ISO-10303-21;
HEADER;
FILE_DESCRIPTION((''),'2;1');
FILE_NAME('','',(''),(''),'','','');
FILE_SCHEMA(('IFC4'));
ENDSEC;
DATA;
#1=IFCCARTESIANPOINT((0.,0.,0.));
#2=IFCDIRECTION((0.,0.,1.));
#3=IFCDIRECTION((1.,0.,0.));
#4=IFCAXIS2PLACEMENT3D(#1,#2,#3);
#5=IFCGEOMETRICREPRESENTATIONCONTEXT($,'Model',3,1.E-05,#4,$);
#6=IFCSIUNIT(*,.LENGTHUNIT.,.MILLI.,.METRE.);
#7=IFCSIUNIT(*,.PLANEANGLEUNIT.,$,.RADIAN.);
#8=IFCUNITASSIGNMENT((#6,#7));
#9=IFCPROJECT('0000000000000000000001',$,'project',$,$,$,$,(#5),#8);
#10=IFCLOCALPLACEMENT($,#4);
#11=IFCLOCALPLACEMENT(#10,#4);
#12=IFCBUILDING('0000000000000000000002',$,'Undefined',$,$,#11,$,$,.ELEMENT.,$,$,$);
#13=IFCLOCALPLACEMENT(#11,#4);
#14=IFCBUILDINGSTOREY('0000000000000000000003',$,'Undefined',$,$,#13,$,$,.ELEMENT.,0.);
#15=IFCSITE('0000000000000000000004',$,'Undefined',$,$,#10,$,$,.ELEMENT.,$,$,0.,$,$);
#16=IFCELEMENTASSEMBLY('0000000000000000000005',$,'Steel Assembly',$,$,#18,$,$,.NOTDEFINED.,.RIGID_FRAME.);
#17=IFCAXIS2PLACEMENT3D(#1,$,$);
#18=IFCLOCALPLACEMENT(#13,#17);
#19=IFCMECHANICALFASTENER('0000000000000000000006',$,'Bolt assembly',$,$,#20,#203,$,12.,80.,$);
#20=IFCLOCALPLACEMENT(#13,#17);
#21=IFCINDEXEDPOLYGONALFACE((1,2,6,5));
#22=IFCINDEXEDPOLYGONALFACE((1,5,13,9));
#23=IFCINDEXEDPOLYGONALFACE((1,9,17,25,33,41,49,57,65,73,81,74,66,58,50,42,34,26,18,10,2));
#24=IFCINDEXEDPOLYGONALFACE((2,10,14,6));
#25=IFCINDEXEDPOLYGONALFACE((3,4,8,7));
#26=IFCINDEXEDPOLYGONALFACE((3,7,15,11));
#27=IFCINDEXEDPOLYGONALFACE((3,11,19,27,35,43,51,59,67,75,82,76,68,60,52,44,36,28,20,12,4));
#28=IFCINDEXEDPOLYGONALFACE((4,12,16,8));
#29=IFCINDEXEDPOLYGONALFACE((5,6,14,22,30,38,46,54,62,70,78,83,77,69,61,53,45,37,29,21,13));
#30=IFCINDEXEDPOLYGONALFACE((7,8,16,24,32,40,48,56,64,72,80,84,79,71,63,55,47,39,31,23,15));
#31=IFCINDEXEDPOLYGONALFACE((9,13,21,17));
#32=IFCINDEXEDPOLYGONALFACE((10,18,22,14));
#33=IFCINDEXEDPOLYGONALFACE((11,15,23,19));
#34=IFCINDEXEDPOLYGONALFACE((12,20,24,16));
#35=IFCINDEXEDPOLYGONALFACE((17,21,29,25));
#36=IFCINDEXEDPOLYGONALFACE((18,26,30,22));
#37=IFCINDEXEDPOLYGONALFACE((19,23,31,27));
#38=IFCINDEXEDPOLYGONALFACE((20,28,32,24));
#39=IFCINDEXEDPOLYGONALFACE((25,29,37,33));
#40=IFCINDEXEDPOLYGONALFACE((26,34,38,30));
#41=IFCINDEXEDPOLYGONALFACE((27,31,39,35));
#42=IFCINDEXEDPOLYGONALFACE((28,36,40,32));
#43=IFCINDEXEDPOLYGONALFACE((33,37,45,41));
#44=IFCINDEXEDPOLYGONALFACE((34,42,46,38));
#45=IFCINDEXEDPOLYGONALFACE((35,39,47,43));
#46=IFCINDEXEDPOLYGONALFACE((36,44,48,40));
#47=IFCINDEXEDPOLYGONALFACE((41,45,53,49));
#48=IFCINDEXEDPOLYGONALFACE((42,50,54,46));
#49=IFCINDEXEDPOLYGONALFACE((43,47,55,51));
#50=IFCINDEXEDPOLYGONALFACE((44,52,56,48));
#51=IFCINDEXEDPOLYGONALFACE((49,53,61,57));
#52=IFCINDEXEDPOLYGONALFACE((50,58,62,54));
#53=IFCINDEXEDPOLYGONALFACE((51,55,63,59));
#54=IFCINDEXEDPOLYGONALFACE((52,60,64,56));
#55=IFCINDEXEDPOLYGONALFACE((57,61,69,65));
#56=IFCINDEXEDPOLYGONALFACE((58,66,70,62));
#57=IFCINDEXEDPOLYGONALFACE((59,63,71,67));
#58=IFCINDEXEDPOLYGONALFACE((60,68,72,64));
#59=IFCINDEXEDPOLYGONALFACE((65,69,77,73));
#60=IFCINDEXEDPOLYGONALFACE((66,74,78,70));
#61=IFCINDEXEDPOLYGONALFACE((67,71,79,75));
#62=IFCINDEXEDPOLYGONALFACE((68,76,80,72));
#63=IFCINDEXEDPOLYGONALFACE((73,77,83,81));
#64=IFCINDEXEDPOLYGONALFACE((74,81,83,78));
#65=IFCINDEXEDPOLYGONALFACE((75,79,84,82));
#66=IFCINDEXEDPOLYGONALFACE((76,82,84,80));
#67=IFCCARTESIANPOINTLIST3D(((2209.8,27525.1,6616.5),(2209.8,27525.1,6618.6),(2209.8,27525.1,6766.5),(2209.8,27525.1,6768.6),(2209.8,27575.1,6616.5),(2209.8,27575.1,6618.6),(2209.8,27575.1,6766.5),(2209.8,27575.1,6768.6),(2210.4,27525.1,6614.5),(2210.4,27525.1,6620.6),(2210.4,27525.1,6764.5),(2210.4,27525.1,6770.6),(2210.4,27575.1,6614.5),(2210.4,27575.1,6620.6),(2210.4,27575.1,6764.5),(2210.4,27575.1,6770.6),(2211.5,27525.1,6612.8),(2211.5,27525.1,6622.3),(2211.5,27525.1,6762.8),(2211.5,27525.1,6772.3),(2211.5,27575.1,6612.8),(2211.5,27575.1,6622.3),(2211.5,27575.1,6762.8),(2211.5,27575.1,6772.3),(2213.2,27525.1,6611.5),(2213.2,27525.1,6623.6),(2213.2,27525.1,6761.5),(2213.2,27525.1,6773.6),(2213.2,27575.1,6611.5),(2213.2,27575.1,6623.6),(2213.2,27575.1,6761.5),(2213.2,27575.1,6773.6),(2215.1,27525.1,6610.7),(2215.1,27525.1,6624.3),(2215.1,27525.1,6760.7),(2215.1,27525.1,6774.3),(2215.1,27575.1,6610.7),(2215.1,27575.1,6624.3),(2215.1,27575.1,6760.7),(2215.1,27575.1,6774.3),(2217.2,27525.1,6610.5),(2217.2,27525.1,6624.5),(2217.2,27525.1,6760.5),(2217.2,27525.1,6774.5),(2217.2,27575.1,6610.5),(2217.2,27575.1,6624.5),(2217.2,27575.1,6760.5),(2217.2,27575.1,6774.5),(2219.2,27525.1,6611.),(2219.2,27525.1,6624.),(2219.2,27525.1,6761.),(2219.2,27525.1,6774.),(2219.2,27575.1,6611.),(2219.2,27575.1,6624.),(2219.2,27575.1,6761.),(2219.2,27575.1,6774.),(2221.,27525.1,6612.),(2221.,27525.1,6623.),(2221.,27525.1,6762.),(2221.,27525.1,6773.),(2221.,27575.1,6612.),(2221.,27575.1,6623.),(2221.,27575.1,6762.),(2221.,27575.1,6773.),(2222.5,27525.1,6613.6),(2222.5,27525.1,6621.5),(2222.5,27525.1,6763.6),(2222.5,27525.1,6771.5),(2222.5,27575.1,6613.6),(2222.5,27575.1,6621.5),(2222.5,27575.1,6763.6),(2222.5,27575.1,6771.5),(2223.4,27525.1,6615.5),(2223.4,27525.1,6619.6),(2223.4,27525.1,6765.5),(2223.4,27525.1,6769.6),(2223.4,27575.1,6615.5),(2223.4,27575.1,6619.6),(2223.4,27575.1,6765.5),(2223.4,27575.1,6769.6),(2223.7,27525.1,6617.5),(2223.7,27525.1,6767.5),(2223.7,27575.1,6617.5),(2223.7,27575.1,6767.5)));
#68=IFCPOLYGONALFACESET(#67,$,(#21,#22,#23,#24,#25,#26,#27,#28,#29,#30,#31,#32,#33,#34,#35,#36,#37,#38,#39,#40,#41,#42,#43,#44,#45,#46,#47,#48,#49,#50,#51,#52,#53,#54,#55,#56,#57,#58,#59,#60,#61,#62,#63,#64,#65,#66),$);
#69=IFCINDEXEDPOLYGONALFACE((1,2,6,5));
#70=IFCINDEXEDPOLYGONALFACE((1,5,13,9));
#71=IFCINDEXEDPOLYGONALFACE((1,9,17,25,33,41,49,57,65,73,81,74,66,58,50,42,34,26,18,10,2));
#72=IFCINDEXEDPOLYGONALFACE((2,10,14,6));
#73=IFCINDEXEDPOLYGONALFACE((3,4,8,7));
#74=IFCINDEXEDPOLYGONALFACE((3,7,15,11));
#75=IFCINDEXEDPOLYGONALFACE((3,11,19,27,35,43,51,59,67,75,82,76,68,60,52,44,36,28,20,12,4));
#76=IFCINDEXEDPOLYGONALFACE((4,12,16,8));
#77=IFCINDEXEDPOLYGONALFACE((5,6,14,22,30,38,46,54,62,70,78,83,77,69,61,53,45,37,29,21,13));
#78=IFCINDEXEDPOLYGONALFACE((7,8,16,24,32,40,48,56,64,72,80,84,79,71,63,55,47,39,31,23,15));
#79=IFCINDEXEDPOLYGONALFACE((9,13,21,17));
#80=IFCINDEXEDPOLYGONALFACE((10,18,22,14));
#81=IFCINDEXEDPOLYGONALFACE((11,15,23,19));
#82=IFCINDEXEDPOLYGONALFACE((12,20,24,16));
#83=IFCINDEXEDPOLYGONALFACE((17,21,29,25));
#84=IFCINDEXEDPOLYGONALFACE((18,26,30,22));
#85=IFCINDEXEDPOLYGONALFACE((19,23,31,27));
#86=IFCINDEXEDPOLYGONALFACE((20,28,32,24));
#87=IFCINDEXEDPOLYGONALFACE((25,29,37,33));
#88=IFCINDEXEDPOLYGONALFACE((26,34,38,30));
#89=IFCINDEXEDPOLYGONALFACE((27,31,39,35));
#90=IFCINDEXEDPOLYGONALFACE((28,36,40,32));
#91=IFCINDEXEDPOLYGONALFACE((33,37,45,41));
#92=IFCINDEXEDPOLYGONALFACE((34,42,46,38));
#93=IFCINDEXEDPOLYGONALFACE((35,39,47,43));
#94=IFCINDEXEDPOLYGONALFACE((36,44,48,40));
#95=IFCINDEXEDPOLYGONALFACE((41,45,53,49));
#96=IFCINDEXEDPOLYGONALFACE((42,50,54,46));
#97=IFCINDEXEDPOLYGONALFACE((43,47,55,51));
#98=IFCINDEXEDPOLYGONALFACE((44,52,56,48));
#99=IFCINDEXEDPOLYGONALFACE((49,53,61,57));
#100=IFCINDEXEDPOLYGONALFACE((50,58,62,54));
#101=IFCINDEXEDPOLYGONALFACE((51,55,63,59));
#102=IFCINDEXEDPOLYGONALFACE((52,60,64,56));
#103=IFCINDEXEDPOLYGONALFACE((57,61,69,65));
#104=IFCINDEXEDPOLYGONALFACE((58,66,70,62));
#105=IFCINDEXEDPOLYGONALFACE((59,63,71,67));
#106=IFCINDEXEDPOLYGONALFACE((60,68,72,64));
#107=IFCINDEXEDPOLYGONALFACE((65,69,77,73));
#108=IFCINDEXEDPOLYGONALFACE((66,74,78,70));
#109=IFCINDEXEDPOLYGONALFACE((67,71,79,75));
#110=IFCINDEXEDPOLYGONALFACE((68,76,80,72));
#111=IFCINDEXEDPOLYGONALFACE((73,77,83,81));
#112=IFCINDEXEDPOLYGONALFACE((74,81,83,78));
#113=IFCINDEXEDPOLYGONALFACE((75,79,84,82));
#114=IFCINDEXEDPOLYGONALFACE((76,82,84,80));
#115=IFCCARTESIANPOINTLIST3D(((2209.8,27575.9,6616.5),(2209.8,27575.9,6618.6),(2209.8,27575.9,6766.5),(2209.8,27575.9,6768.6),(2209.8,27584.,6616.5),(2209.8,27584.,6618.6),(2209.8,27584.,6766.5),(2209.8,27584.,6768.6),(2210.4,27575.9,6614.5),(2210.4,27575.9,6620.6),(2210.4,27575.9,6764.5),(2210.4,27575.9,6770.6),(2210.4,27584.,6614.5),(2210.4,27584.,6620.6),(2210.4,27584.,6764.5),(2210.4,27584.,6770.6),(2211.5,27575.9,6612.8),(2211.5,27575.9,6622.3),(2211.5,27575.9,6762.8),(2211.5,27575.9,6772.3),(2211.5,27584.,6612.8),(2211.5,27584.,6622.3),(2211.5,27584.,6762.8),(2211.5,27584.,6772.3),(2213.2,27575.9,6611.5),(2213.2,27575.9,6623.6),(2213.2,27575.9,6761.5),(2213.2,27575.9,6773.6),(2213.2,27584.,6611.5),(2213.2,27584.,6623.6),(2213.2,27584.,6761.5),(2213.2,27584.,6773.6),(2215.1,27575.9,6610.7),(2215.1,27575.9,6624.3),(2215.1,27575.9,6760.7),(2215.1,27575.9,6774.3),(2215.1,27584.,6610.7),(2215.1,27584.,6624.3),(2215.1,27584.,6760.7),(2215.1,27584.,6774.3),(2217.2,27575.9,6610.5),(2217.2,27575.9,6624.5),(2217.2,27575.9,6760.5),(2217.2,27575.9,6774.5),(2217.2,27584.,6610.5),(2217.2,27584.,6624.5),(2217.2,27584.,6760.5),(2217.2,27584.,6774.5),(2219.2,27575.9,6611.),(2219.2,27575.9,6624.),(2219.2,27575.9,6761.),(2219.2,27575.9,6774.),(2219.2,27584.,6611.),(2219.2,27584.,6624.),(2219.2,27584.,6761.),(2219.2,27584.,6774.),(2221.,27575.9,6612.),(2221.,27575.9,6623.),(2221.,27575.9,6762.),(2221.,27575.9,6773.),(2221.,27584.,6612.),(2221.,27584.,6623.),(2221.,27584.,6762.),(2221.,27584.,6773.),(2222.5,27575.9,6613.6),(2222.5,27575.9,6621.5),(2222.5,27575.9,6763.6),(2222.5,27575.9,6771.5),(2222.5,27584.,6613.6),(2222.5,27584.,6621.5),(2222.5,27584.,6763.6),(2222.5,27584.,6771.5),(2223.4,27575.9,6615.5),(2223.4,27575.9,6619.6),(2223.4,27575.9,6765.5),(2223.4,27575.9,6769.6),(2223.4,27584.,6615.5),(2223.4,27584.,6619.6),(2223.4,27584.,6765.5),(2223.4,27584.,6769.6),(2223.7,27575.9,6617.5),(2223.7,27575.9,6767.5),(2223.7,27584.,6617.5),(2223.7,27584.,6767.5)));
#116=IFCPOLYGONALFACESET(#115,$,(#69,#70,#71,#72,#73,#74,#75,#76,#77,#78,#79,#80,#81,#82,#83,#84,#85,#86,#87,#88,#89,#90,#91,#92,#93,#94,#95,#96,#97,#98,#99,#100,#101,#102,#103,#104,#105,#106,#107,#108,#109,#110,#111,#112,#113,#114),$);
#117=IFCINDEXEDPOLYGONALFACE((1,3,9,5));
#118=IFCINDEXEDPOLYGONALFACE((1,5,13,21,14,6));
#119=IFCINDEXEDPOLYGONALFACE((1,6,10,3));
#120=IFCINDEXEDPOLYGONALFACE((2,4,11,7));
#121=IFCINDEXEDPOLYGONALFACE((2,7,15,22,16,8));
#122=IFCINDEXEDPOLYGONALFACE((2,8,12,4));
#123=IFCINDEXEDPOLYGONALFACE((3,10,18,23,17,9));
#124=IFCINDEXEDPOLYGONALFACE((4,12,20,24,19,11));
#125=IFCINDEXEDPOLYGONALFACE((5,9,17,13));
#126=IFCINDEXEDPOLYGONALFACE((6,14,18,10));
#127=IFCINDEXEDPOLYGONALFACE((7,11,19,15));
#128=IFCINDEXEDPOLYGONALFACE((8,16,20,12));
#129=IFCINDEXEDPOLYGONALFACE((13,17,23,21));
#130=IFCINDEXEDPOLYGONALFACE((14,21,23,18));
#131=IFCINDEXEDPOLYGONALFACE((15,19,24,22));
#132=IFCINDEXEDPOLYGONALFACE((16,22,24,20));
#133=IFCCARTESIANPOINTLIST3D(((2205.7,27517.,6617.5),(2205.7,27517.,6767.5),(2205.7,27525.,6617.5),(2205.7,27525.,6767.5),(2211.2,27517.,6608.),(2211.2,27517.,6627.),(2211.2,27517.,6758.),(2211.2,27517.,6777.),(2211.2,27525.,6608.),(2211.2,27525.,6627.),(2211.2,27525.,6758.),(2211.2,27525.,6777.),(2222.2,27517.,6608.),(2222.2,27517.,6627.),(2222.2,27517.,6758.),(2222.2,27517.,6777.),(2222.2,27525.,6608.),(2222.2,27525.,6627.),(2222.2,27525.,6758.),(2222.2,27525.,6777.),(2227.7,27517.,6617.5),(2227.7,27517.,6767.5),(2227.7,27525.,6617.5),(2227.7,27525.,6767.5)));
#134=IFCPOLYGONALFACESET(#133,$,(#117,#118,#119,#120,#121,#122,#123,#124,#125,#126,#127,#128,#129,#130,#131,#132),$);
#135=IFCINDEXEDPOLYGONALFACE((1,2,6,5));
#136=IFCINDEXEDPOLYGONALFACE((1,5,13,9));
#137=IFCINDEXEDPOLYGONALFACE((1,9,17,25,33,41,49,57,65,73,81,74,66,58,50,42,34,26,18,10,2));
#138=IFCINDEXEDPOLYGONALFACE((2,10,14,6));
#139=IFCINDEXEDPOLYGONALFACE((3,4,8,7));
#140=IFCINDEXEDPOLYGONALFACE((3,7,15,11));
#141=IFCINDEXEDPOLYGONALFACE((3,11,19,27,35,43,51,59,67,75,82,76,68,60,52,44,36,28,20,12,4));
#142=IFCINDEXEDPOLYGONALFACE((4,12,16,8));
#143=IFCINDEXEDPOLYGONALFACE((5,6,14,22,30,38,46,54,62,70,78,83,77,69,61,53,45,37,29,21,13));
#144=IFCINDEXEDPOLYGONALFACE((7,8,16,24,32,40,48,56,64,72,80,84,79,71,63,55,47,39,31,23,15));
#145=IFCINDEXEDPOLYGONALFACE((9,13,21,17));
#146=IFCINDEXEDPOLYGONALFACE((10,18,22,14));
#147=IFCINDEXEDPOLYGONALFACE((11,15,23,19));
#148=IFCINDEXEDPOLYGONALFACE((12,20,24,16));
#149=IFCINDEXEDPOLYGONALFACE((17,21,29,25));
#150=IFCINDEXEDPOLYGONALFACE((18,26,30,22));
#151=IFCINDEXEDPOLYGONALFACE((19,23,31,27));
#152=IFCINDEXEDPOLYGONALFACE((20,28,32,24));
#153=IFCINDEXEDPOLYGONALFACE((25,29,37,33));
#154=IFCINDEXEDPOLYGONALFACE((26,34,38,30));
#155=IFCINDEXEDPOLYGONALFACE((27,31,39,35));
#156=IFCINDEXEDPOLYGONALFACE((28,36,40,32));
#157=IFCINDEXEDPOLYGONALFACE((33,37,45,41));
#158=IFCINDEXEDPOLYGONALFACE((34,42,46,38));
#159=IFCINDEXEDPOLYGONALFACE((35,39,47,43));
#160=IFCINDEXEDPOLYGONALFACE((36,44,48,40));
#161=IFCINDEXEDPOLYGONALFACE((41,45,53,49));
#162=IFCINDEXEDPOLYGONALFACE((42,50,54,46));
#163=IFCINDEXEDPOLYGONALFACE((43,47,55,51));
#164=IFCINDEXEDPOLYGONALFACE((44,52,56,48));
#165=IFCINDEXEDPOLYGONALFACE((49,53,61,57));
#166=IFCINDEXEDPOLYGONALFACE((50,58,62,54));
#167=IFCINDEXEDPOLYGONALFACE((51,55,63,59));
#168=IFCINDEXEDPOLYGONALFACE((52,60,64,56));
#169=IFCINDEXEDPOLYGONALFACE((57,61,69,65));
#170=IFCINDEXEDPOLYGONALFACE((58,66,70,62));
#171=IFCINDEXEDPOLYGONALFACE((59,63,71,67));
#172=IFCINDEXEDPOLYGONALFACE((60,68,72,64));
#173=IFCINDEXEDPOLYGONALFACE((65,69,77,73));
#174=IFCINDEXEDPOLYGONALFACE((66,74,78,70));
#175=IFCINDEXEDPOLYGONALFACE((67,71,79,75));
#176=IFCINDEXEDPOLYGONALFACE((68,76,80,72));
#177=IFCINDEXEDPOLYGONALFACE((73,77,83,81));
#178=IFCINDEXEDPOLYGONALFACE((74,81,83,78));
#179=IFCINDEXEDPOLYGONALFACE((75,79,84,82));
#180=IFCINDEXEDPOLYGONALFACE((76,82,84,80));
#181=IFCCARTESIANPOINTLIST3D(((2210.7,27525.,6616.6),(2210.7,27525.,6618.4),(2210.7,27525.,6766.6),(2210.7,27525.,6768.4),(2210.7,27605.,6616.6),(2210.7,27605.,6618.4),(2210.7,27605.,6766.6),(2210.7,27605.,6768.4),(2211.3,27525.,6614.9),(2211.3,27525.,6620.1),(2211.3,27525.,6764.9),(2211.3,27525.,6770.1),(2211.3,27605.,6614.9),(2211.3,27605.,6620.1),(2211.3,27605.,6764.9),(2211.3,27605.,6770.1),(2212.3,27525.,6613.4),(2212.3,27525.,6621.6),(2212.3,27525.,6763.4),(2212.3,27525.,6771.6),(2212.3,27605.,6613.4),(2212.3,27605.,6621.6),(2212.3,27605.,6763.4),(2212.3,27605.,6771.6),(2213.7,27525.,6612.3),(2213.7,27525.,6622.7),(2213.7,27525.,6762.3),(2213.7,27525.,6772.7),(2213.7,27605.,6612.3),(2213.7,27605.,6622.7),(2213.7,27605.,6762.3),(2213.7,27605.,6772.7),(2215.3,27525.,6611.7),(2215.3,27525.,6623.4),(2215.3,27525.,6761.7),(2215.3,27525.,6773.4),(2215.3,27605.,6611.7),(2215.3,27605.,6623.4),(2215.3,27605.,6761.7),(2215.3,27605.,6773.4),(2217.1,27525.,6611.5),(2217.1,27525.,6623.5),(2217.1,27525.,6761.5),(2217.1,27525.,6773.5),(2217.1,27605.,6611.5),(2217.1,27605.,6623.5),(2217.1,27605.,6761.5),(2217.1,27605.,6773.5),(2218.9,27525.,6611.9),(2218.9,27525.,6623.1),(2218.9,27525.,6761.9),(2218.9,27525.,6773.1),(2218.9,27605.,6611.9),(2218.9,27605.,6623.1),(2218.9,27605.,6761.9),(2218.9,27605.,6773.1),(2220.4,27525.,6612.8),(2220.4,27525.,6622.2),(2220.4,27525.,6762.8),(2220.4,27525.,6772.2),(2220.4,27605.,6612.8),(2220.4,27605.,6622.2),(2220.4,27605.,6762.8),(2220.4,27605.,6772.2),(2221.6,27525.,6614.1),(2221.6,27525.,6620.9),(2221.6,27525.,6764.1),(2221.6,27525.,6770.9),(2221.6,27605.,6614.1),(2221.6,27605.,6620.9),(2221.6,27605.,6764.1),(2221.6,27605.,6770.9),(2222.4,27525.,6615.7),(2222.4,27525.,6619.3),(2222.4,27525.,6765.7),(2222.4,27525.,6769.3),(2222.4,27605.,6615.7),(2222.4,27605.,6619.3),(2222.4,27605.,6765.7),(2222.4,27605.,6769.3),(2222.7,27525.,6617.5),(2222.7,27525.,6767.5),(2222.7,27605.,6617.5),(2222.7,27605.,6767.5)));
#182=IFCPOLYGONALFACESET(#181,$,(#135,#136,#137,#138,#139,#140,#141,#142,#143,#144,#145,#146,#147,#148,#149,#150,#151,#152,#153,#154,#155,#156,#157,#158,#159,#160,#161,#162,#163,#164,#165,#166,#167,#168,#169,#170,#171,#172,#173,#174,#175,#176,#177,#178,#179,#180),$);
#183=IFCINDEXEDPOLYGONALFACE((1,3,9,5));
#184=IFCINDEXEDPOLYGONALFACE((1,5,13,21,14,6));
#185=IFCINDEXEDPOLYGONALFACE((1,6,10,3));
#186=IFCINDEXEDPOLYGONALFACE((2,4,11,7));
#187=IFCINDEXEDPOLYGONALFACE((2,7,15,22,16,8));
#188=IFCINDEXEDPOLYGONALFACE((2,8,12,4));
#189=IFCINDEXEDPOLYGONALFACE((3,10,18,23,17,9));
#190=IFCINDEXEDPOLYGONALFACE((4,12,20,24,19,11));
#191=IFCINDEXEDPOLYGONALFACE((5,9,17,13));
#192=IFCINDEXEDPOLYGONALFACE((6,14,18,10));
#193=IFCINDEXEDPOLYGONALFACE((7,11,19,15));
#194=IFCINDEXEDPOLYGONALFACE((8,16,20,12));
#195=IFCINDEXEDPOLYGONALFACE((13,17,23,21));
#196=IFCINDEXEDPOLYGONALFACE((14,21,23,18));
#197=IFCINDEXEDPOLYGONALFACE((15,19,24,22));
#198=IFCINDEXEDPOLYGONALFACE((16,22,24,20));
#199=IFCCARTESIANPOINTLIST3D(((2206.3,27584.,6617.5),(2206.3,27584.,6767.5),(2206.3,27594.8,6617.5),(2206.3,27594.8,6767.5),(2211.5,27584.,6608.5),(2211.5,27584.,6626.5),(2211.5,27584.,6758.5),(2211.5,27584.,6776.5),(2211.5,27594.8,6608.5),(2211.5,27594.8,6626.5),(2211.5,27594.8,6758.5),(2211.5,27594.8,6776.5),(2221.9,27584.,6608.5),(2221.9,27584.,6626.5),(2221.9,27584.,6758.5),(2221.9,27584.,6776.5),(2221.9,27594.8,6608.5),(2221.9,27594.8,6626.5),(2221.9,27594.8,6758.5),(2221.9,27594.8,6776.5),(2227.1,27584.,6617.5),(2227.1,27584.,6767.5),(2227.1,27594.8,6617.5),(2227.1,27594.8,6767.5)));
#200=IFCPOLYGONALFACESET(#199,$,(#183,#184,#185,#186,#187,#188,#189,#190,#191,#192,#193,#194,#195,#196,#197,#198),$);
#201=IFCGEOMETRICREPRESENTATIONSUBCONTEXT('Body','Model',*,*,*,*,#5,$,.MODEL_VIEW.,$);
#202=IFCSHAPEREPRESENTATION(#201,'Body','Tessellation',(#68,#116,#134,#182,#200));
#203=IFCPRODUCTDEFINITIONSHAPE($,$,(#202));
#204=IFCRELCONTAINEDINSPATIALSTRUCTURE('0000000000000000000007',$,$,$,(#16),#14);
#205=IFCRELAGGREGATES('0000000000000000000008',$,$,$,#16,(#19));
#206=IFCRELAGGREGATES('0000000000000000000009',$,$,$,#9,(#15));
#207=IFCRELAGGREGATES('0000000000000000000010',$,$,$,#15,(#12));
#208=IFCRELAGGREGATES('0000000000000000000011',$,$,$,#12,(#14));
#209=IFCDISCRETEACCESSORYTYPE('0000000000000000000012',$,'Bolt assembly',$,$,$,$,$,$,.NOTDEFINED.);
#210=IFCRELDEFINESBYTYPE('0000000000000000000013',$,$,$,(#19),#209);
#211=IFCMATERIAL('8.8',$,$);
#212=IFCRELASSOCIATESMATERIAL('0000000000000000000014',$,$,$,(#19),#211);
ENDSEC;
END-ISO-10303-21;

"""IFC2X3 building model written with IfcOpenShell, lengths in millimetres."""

from ifc_helpers import new_model, si_unit, frame, origin_with_axes, origin_2d_with_axis, place, context, subcontext, project, spatial, polyline, circle, outline, extrude, source, transform, mapped, material, type_object, element, aggregate, save


model = new_model("IFC2X3")

# Units and contexts
model_context = context("Model", 3, precision=1e-05, world=origin_with_axes())
body_context = subcontext(model_context, "Body", "Model", "MODEL_VIEW")
ifc_project = project(units=[si_unit("LENGTHUNIT", "METRE", prefix="MILLI"), si_unit("PLANEANGLEUNIT", "RADIAN")], contexts=[model_context])

# Site, building, storey
site_placement = place(None, origin_with_axes())
site = spatial("IfcSite", under=ifc_project, at=site_placement, Name="Undefined", CompositionType="ELEMENT", RefElevation=0.0)
building_placement = place(site_placement, origin_with_axes())
building = spatial("IfcBuilding", under=site, at=building_placement, Name="Undefined", CompositionType="ELEMENT")
storey_placement = place(building_placement, origin_with_axes())
storey = spatial("IfcBuildingStorey", under=building, at=storey_placement, Name="Undefined", CompositionType="ELEMENT", Elevation=0.0)

# Element assembly
assembly_1_placement = place(storey_placement, origin_with_axes())
assembly_1 = element("IfcElementAssembly", 1, at=assembly_1_placement, inside=storey, Name="Steel Assembly", AssemblyPlace="NOTDEFINED", PredefinedType="RIGID_FRAME")

# Shared definitions
ifc_material_1 = material(Name="8.8")
discrete_accessory_type_1 = type_object("IfcDiscreteAccessoryType", Name="Bolt assembly")
shared_shape_1 = source(origin_with_axes(), body_context, "Body", "SweptSolid", [
    extrude(circle(Radius=7.0, at=origin_2d_with_axis()), frame((0.0, -52.9, 0.0), z_axis=(0.0, 1.0, 0.0), x_axis=(1.0, 0.0, 0.0)), (0.0, 0.0, 1.0), 50.0),
    extrude(circle(Radius=7.0, at=origin_2d_with_axis()), frame((0.0, -2.1, 0.0), z_axis=(0.0, 1.0, 0.0), x_axis=(1.0, 0.0, 0.0)), (0.0, 0.0, 1.0), 8.1),
    extrude(outline(polyline([(11.0, 0.0), (5.5, 9.5), (-5.5, 9.5), (-11.0, 0.0), (-5.5, -9.5), (5.5, -9.5), (11.0, 0.0)])), frame((0.0, -61.0, 0.0), z_axis=(0.0, 1.0, 0.0), x_axis=(1.0, 0.0, 0.0)), (0.0, 0.0, 1.0), 8.0),
    extrude(circle(Radius=6.0, at=origin_2d_with_axis()), frame((0.0, -53.0, 0.0), z_axis=(0.0, 1.0, 0.0), x_axis=(1.0, 0.0, 0.0)), (0.0, 0.0, 1.0), 80.0),
    extrude(outline(polyline([(10.4, 0.0), (5.2, 9.0), (-5.2, 9.0), (-10.4, 0.0), (-5.2, -9.0), (5.2, -9.0), (10.4, 0.0)])), frame((0.0, 6.0, 0.0), z_axis=(0.0, 1.0, 0.0), x_axis=(1.0, 0.0, 0.0)), (0.0, 0.0, 1.0), 10.8),
])

# Mechanical fastener
mechanical_fastener_1_placement = place(assembly_1_placement, frame((2191.7, 27578.0, 6692.5), z_axis=(0.0, 0.0, 1.0), x_axis=(1.0, 0.0, 0.0)))
mechanical_fastener_1 = element("IfcMechanicalFastener", 2, at=mechanical_fastener_1_placement, type_object=discrete_accessory_type_1, material=ifc_material_1, Name="Bolt assembly", NominalDiameter=12.0, NominalLength=80.0, context=body_context, shape_type="MappedRepresentation", body=[
    mapped(shared_shape_1, transform((25.0, 0.0, -75.0))),
    mapped(shared_shape_1, transform((25.0, 0.0, 75.0))),
])

aggregate(assembly_1, [mechanical_fastener_1])

save(model, "model.ifc")
